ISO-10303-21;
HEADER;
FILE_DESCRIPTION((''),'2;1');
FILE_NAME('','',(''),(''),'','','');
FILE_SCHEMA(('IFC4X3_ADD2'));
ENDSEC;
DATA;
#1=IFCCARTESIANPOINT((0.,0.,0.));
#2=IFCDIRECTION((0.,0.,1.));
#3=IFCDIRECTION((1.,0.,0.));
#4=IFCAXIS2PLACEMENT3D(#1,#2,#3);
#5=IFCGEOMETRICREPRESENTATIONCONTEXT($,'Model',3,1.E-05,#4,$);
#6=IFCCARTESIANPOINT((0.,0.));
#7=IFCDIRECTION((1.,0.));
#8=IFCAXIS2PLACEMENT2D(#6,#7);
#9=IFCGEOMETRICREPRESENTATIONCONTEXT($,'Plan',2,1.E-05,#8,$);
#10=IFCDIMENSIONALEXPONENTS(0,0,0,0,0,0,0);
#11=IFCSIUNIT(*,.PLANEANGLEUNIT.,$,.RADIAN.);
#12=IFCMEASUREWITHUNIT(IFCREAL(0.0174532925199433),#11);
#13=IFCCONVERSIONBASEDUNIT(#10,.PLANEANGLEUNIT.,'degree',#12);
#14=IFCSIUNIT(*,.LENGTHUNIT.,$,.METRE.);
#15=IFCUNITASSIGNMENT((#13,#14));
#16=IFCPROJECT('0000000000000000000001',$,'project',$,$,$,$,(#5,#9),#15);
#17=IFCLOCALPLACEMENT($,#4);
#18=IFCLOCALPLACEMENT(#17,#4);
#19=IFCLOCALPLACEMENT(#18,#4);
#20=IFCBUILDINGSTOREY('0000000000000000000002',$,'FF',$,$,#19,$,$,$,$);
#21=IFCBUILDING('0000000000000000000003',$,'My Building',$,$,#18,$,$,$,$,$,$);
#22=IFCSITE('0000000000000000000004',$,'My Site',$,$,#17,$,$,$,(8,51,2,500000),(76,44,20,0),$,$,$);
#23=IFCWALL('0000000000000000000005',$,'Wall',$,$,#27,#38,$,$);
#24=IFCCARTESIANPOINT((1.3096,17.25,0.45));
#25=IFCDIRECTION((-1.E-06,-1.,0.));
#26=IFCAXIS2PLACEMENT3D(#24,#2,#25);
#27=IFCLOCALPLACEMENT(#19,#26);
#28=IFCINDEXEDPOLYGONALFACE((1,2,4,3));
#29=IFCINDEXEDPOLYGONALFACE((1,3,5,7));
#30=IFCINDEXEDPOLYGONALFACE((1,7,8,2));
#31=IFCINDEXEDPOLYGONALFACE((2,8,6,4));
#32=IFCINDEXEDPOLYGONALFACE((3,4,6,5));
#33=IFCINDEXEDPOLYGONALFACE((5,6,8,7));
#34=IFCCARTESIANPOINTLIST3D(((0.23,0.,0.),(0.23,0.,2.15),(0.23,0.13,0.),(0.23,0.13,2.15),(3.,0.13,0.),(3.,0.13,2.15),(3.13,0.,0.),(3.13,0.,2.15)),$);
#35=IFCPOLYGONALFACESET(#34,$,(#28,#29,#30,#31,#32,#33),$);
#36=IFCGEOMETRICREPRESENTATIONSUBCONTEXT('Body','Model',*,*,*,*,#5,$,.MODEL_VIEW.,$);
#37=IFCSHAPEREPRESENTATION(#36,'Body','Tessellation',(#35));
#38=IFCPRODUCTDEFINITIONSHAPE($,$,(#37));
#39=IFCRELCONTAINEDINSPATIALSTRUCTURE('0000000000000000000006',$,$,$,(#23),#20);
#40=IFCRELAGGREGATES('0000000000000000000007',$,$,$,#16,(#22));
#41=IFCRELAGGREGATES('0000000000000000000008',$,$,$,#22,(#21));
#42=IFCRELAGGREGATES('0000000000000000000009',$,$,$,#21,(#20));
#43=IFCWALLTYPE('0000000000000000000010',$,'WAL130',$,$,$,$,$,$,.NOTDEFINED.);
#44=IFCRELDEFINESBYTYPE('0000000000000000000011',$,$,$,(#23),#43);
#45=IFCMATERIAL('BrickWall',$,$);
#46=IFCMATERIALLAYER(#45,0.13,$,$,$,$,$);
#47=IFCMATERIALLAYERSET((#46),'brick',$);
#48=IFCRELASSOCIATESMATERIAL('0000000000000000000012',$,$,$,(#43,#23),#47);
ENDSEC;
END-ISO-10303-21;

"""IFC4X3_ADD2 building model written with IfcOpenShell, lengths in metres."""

from ifc_helpers import new_model, entity, si_unit, converted_unit, frame, origin_with_axes, origin_2d_with_axis, place, context, subcontext, project, spatial, line, indexed_curve, outline, extrude, material, layer, layer_set, layer_usage, type_object, element, save


model = new_model("IFC4X3_ADD2")

# Units and contexts
model_context = context("Model", 3, precision=1e-05, world=origin_with_axes())
plan_context = context("Plan", 2, precision=1e-05, world=origin_2d_with_axis())
body_context = subcontext(model_context, "Body", "Model", "MODEL_VIEW")
ifc_project = project(units=[converted_unit("PLANEANGLEUNIT", "degree", entity("IfcReal", 0.0174532925199433), si_unit("PLANEANGLEUNIT", "RADIAN"), dimensions=[0, 0, 0, 0, 0, 0, 0]), si_unit("LENGTHUNIT", "METRE")], contexts=[model_context, plan_context])

# Site, building, storey
site_placement = place(None, origin_with_axes())
site = spatial("IfcSite", under=ifc_project, at=site_placement, Name="My Site", RefLatitude=(8, 51, 2, 500000), RefLongitude=(76, 44, 20, 0))
building_placement = place(site_placement, origin_with_axes())
building = spatial("IfcBuilding", under=site, at=building_placement, Name="My Building")
storey_placement = place(building_placement, origin_with_axes())
storey = spatial("IfcBuildingStorey", under=building, at=storey_placement, Name="FF")

# Shared definitions
ifc_material_1 = material(Name="BrickWall")

# Wall
ifc_layer_1 = layer(ifc_material_1, 0.13)
ifc_layer_set_1 = layer_set([ifc_layer_1], Name="brick")
ifc_layer_usage_1 = layer_usage(ifc_layer_set_1, "AXIS2", "POSITIVE", 0.0)
wall_type_1 = type_object("IfcWallType", Name="WAL130", PredefinedType="NOTDEFINED", material=ifc_layer_set_1)
wall_1_placement = place(storey_placement, frame((1.3096, 17.25, 0.45), z_axis=(0.0, 0.0, 1.0), x_axis=(-0.000001, -1.0, 0.0)))
element("IfcWall", 1, at=wall_1_placement, inside=storey, type_object=wall_type_1, material=ifc_layer_usage_1, Name="Wall", context=body_context, shape_type="SweptSolid", body=[
    extrude(outline(indexed_curve([(0.23, 0.0), (0.23, 0.13), (3.0, 0.13), (3.13, 0.0)], segments=[line(1, 2, 3, 4, 1)])), origin_with_axes(), (0.0, 0.0, 1.0), 2.15),
])

save(model, "model.ifc")
